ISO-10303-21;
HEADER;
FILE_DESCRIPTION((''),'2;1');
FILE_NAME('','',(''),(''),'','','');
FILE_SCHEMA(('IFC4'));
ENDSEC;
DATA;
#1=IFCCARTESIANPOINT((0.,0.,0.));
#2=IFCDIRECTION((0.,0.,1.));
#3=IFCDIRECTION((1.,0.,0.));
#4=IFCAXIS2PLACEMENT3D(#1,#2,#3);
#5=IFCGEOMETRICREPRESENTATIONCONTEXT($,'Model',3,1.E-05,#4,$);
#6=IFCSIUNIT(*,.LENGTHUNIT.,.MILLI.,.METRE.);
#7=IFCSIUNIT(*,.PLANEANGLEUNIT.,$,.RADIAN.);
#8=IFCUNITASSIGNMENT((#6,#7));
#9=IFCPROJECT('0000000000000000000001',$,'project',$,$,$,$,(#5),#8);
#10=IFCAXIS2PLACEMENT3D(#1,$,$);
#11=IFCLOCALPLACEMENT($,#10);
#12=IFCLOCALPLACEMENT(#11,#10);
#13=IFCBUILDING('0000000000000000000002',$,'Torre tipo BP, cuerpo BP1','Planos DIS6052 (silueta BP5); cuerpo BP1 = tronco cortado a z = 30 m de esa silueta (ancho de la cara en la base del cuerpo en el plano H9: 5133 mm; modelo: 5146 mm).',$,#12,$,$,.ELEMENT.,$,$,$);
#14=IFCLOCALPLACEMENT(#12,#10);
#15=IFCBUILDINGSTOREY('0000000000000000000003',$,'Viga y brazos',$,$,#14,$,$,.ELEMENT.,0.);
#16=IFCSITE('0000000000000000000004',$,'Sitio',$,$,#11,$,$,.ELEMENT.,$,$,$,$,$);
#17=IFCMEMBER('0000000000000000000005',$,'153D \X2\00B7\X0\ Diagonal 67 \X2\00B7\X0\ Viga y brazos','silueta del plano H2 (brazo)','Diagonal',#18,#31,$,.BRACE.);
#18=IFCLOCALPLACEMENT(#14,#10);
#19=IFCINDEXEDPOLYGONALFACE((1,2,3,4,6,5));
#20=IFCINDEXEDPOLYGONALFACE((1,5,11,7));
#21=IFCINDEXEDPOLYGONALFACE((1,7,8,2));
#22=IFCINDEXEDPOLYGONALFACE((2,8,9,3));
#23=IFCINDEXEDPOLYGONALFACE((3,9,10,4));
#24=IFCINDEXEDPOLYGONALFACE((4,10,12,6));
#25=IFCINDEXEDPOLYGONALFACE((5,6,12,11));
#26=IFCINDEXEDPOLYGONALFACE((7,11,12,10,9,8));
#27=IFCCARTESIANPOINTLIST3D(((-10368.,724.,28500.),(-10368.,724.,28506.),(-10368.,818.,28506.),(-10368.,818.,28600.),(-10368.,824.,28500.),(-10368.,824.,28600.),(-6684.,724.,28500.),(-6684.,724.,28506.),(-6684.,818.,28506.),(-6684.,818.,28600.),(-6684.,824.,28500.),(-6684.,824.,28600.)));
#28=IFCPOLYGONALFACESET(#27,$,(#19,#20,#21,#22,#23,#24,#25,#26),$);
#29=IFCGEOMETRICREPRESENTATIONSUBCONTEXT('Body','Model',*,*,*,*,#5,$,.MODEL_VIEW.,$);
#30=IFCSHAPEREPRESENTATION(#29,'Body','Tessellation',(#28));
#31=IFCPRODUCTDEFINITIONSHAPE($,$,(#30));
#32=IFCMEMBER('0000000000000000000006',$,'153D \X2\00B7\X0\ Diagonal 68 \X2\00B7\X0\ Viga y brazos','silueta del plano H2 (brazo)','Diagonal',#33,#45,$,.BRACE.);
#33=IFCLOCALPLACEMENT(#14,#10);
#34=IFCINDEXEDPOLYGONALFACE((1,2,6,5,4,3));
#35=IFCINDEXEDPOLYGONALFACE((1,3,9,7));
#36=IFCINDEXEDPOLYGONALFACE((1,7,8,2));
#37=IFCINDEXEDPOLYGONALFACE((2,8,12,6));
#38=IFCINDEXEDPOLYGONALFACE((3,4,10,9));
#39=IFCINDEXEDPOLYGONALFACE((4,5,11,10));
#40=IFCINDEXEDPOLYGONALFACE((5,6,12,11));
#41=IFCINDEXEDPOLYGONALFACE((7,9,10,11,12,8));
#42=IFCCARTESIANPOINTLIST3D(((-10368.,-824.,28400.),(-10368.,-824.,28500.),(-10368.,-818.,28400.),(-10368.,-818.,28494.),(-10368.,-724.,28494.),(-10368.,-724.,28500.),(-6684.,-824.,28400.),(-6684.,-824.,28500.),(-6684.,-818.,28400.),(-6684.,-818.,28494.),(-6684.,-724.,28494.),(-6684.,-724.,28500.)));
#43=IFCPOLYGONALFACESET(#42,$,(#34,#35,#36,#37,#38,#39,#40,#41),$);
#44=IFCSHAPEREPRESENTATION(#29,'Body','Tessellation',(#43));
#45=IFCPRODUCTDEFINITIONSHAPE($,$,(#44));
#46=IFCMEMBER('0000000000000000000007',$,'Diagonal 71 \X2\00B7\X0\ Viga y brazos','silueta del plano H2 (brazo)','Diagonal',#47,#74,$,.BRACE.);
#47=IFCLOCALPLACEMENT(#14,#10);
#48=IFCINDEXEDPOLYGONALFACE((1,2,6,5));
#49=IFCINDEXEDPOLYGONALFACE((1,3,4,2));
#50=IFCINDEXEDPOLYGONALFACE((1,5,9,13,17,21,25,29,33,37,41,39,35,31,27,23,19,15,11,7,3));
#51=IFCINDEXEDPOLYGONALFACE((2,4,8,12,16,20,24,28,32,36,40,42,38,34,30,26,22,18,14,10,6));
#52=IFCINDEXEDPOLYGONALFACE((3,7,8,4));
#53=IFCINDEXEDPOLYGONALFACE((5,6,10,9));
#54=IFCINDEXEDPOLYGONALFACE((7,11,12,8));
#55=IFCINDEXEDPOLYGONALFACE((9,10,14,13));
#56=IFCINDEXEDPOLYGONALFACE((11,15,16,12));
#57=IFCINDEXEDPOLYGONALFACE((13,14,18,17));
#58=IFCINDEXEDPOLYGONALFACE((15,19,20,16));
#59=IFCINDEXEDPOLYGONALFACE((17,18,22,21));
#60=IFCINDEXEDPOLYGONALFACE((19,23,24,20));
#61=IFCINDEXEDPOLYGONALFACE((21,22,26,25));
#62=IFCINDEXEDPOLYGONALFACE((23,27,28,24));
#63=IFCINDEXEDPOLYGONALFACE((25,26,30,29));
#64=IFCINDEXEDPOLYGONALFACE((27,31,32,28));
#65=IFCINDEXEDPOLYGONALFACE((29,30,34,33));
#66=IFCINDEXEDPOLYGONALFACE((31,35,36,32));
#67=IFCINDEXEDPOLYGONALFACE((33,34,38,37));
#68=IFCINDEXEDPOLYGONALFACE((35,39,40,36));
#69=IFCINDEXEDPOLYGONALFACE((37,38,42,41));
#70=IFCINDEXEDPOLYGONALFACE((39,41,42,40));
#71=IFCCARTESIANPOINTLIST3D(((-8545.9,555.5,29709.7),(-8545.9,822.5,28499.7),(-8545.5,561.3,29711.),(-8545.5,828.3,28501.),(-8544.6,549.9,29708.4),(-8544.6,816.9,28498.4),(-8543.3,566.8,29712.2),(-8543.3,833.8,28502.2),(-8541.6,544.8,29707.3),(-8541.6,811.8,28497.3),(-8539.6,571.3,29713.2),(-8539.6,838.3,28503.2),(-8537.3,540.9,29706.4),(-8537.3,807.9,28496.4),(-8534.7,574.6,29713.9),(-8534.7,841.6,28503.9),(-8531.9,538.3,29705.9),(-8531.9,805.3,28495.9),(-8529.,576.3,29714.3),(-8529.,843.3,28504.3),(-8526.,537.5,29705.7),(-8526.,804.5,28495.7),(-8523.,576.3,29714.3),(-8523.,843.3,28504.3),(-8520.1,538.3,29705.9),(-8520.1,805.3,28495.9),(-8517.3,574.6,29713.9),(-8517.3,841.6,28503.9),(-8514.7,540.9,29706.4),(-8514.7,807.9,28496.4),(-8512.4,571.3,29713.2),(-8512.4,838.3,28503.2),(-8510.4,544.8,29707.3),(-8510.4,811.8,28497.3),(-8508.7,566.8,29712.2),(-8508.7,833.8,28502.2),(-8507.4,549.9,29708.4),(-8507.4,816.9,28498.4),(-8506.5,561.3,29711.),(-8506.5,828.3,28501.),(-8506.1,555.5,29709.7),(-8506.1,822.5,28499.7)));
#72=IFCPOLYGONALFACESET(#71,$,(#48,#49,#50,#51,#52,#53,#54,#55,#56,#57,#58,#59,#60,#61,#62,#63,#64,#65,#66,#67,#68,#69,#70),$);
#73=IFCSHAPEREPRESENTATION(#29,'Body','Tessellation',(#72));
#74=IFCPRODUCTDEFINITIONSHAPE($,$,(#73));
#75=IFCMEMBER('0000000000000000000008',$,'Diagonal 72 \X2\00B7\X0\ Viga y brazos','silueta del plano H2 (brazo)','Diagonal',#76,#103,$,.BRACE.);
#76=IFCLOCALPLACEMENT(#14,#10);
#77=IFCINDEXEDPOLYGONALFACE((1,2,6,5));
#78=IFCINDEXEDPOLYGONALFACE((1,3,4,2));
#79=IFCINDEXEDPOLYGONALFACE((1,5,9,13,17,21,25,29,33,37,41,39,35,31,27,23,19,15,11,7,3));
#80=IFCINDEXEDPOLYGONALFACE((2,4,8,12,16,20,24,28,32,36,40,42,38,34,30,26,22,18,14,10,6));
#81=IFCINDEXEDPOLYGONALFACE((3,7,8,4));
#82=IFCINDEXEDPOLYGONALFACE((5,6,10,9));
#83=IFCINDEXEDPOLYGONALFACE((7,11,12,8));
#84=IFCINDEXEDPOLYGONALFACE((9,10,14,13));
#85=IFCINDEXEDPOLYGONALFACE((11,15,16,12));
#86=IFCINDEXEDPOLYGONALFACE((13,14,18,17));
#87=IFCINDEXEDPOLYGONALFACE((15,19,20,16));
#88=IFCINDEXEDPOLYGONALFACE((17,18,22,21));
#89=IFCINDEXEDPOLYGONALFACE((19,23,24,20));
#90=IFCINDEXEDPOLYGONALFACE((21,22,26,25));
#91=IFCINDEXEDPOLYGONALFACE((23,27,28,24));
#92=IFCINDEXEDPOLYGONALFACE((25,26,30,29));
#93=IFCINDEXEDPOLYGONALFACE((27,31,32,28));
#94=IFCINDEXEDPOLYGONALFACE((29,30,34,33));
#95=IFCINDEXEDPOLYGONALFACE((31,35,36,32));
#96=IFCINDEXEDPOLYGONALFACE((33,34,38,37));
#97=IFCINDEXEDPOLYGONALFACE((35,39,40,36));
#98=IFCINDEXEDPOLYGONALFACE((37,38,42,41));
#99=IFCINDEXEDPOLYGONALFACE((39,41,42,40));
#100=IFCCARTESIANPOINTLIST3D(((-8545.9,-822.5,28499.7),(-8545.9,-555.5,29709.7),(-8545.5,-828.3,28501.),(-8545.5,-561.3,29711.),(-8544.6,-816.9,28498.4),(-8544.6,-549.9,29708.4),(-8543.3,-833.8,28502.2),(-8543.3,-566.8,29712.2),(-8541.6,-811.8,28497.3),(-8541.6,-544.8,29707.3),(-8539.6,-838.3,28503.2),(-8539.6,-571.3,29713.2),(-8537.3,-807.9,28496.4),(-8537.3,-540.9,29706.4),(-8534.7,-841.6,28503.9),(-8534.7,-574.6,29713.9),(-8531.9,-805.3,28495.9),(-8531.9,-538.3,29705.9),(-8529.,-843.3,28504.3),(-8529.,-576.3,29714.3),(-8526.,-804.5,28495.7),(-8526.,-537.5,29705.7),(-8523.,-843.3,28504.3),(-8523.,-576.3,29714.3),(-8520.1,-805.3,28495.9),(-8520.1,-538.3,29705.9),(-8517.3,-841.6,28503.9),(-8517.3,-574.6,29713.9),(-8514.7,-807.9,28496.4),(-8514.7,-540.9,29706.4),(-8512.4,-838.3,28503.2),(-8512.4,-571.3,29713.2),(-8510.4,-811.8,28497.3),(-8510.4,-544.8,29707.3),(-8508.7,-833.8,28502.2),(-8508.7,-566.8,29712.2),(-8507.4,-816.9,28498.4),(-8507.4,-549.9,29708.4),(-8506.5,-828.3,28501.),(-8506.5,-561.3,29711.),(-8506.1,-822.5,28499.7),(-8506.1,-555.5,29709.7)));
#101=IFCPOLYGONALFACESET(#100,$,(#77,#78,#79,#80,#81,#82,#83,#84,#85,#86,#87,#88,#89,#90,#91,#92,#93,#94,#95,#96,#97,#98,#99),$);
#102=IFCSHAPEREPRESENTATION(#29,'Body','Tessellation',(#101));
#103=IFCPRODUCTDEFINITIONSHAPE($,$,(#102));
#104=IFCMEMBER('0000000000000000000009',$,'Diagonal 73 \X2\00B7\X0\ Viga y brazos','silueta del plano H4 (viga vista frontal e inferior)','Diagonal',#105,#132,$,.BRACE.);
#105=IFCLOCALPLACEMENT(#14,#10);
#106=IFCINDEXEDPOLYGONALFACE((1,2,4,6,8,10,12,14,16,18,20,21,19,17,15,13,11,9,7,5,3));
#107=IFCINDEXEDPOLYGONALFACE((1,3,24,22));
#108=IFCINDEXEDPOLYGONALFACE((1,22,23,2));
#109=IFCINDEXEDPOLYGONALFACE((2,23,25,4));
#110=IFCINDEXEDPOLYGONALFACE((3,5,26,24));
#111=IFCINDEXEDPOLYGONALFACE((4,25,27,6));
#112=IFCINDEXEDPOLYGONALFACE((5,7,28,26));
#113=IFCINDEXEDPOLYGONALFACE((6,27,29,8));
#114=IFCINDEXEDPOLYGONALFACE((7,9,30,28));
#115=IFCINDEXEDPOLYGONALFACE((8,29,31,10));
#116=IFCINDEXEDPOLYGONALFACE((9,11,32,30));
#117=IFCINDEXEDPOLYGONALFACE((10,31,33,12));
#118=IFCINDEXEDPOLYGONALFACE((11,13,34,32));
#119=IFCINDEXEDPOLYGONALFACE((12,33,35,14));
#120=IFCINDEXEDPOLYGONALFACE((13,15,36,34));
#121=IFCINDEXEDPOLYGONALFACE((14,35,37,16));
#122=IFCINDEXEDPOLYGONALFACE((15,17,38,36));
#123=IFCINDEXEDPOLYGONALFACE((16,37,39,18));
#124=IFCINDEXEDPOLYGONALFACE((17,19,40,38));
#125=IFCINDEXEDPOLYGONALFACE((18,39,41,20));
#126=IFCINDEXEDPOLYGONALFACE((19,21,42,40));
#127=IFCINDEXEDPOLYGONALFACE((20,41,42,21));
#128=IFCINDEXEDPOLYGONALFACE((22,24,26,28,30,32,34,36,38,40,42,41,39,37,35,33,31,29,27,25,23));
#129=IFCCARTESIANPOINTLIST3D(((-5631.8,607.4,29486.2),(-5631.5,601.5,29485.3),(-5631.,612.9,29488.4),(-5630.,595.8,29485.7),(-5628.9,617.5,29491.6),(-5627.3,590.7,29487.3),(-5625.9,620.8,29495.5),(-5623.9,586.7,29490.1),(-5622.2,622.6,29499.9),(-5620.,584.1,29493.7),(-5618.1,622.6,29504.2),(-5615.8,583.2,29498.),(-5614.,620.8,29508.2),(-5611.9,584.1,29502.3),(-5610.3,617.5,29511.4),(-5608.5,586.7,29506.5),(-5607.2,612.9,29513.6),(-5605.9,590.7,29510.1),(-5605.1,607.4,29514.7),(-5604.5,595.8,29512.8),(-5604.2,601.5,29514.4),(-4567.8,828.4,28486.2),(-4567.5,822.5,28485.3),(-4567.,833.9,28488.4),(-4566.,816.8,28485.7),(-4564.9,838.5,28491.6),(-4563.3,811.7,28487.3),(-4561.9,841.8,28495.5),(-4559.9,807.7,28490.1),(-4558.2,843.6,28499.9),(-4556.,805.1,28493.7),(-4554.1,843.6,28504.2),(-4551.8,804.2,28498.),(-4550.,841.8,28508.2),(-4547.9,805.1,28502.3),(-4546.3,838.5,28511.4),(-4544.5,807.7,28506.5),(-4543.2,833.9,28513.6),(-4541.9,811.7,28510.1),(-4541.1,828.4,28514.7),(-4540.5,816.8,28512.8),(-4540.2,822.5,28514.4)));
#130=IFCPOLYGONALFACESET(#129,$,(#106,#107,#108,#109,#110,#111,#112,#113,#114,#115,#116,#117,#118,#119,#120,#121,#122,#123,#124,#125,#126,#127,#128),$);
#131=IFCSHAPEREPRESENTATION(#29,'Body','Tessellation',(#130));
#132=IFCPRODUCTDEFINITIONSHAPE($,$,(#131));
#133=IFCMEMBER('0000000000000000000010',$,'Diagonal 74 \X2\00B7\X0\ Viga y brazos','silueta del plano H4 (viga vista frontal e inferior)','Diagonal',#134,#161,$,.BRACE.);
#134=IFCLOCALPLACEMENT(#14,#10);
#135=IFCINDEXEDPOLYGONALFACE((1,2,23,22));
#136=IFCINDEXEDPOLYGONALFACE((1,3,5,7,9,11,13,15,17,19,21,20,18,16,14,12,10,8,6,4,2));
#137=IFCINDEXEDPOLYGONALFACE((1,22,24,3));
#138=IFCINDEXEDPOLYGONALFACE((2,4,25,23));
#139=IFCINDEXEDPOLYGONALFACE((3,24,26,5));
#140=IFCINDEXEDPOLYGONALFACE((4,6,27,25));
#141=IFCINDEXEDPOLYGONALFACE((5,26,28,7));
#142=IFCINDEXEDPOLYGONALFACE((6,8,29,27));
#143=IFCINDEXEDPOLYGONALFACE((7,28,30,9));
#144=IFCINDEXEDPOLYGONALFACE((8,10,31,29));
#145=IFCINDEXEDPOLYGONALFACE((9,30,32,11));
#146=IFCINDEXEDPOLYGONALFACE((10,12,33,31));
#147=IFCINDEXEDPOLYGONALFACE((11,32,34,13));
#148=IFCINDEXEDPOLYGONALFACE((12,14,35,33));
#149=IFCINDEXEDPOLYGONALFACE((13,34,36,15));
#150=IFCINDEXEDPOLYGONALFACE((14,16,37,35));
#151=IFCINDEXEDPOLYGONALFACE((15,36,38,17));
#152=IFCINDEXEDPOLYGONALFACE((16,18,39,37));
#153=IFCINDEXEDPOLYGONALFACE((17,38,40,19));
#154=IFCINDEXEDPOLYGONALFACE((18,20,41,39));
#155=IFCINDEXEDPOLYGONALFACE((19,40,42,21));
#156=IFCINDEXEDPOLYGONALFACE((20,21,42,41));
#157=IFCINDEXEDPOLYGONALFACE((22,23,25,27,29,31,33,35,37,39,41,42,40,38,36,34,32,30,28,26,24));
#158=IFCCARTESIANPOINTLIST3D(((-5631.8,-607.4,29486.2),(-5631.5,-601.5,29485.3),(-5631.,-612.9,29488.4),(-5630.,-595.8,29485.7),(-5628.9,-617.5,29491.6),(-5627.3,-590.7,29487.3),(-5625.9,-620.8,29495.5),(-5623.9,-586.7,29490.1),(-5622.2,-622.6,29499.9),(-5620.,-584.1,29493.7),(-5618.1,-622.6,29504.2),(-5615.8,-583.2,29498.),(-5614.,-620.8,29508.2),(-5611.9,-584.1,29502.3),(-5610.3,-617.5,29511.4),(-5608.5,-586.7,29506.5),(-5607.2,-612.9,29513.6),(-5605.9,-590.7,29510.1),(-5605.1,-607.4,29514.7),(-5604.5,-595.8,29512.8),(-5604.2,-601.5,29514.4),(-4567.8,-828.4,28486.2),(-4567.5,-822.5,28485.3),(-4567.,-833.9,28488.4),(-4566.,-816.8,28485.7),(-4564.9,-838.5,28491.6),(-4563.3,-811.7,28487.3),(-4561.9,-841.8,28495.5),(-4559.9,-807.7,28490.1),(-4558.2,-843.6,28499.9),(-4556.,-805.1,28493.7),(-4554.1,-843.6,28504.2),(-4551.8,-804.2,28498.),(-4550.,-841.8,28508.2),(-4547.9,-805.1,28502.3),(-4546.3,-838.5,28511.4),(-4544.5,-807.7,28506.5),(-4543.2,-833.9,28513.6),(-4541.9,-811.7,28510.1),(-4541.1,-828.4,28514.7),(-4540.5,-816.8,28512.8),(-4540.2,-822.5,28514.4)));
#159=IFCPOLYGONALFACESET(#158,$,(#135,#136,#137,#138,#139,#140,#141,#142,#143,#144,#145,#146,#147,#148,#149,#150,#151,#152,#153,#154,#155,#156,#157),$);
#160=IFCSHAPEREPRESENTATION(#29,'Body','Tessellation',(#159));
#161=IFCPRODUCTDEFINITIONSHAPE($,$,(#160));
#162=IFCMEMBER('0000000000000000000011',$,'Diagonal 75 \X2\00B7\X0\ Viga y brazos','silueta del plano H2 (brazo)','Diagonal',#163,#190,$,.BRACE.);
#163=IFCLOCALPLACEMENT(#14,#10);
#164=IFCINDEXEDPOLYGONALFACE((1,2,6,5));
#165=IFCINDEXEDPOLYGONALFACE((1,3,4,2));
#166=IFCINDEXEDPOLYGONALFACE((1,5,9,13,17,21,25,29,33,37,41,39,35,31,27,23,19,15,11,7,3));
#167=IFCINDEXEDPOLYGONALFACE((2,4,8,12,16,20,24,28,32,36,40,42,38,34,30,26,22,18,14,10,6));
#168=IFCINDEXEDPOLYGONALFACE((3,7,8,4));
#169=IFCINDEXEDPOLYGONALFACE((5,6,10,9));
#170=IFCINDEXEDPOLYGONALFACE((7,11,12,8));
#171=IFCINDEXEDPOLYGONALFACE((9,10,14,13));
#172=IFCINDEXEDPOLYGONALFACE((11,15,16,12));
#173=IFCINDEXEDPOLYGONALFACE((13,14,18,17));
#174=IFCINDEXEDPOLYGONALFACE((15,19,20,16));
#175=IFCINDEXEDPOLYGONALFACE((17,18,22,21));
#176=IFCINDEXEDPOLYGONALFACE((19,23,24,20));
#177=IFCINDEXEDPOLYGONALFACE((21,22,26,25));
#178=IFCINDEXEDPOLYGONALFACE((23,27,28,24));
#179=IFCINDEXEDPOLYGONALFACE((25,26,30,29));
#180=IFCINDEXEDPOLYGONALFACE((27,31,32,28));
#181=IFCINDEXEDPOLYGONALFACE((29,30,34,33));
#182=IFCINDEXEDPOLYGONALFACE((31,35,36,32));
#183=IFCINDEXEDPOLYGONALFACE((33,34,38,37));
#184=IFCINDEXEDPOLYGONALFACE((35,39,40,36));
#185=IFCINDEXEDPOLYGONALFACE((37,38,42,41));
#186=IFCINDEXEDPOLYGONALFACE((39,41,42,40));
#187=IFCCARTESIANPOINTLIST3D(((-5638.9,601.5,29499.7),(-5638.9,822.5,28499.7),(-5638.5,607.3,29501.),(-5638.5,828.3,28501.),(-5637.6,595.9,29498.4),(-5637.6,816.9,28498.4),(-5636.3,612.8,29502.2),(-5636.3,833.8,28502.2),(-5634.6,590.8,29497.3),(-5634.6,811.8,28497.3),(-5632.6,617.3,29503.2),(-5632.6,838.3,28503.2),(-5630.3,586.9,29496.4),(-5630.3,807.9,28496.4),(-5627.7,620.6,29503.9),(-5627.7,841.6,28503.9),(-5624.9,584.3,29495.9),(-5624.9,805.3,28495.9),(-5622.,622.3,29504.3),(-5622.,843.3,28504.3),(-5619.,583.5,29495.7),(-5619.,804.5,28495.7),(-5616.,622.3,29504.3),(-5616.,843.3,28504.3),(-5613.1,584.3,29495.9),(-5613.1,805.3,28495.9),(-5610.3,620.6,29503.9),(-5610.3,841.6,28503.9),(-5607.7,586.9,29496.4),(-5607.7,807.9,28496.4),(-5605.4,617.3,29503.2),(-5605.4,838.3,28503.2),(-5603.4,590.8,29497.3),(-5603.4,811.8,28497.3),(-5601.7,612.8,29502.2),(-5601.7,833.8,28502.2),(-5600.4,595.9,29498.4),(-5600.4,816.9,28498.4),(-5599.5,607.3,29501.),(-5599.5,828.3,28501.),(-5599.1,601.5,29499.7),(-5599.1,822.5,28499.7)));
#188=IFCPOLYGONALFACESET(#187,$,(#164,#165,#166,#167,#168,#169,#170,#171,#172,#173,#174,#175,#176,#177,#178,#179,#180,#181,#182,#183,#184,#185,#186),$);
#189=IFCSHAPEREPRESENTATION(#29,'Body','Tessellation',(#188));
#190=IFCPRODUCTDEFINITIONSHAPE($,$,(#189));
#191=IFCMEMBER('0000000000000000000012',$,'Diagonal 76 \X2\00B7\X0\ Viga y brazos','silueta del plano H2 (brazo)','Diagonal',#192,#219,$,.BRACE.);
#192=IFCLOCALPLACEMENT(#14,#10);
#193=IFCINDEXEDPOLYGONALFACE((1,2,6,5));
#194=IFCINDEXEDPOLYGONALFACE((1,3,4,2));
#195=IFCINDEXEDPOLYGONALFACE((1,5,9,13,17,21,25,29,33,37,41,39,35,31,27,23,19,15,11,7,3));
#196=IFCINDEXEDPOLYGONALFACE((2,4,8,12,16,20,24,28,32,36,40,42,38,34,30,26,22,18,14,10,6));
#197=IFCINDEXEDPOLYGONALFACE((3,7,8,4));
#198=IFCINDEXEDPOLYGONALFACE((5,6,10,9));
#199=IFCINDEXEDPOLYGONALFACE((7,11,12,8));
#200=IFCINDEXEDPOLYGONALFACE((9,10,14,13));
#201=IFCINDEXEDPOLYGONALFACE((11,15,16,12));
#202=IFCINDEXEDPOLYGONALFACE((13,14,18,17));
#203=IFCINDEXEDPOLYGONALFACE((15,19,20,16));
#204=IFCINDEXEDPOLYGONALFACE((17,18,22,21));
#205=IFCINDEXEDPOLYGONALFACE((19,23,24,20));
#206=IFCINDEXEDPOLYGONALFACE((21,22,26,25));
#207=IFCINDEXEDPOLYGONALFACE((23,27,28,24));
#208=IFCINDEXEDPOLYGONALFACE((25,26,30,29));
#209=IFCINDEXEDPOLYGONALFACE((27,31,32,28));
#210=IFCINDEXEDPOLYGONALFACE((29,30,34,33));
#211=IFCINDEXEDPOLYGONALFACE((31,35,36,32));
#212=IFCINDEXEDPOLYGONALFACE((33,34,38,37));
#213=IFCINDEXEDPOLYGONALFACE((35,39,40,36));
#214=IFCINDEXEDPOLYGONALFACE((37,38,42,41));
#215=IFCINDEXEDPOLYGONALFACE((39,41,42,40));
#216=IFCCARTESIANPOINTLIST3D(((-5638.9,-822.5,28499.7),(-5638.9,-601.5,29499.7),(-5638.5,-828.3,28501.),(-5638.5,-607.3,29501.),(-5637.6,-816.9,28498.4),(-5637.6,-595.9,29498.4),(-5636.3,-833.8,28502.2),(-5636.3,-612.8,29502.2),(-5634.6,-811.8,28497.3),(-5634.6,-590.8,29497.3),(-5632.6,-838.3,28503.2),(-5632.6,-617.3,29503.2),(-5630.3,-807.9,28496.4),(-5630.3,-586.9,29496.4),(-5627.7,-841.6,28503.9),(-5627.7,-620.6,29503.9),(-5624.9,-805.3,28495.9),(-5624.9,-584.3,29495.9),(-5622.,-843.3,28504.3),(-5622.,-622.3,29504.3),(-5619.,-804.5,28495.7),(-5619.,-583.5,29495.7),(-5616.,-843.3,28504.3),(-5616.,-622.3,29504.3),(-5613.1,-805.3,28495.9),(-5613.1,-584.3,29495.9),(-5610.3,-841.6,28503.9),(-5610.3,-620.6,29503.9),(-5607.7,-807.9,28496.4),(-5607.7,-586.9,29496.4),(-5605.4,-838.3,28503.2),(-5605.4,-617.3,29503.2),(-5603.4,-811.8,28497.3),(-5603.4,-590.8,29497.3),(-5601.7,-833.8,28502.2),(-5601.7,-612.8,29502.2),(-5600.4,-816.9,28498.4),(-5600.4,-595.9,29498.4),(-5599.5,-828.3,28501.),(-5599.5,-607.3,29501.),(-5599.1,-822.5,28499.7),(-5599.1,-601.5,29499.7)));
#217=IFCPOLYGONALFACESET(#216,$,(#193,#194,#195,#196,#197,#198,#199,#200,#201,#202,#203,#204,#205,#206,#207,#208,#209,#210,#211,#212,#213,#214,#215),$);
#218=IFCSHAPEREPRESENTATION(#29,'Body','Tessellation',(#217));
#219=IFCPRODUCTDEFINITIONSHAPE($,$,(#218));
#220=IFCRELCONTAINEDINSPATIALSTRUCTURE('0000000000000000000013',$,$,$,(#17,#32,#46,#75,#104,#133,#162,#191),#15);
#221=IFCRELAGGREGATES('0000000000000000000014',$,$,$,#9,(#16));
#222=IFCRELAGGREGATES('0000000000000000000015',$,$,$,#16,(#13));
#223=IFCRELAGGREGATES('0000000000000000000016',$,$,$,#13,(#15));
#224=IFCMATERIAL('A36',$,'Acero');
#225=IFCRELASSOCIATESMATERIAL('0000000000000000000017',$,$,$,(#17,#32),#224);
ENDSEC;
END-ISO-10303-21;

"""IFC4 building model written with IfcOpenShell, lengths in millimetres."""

from ifc_helpers import new_model, si_unit, frame, frame_2d, origin, origin_with_axes, place, context, subcontext, project, spatial, circle, l_section, extrude, material, element, save


model = new_model("IFC4")

# Units and contexts
model_context = context("Model", 3, precision=1e-05, world=origin_with_axes())
body_context = subcontext(model_context, "Body", "Model", "MODEL_VIEW")
ifc_project = project(units=[si_unit("LENGTHUNIT", "METRE", prefix="MILLI"), si_unit("PLANEANGLEUNIT", "RADIAN")], contexts=[model_context])

# Site, building, storey
site_placement = place(None, origin())
site = spatial("IfcSite", under=ifc_project, at=site_placement, Name="Sitio", CompositionType="ELEMENT")
building_placement = place(site_placement, origin())
building = spatial("IfcBuilding", under=site, at=building_placement, Name="Torre tipo BP, cuerpo BP1", Description="Planos DIS6052 (silueta BP5); cuerpo BP1 = tronco cortado a z = 30 m de esa silueta (ancho de la cara en la base del cuerpo en el plano H9: 5133 mm; modelo: 5146 mm).", CompositionType="ELEMENT")
storey_placement = place(building_placement, origin())
storey = spatial("IfcBuildingStorey", under=building, at=storey_placement, Name="Viga y brazos", CompositionType="ELEMENT", Elevation=0.0)

# Members
ifc_material_1 = material(Name="A36", Category="Acero")
for number, where, z_axis, x_axis, name in (
    (1, (-6684.0, 824.0, 28500.0), (-1.0, 0.0, 0.0), (0.0, -1.0, 0.0), "153D · Diagonal 67 · Viga y brazos"),
    (2, (-6684.0, -824.0, 28500.0), (-1.0, 0.0, 0.0), (0.0, 1.0, 0.0), "153D · Diagonal 68 · Viga y brazos"),
):
    element("IfcMember", number, at=place(storey_placement, frame(where, z_axis=z_axis, x_axis=x_axis)), inside=storey, material=ifc_material_1, Name=name, Description="silueta del plano H2 (brazo)", ObjectType="Diagonal", PredefinedType="BRACE", context=body_context, shape_type="SweptSolid", body=[
        extrude(l_section(Depth=100.0, Width=100.0, Thickness=6.0, at=frame_2d((50.0, 50.0))), None, (0.0, 0.0, 1.0), 3684.0),
    ])
for number, where, z_axis, x_axis, name in (
    (3, (-8526.0, 557.0, 29710.0), (0.0, 0.215478, -0.976509), (0.0, -0.976509, -0.215478), "Diagonal 71 · Viga y brazos"),
    (4, (-8526.0, -557.0, 29710.0), (0.0, -0.215478, -0.976509), (0.0, 0.976509, -0.215478), "Diagonal 72 · Viga y brazos"),
):
    element("IfcMember", number, at=place(storey_placement, frame(where, z_axis=z_axis, x_axis=x_axis)), inside=storey, Name=name, Description="silueta del plano H2 (brazo)", ObjectType="Diagonal", PredefinedType="BRACE", context=body_context, shape_type="SweptSolid", body=[
        extrude(circle(Radius=20.0), None, (0.0, 0.0, 1.0), 1239.1),
    ])
for number, where, z_axis, x_axis, name in (
    (5, (-4554.0, 824.0, 28500.0), (-0.720477, -0.149648, 0.67714), (0.109046, -0.988739, -0.102487), "Diagonal 73 · Viga y brazos"),
    (6, (-4554.0, -824.0, 28500.0), (-0.720477, 0.149648, 0.67714), (0.109046, 0.988739, -0.102487), "Diagonal 74 · Viga y brazos"),
):
    element("IfcMember", number, at=place(storey_placement, frame(where, z_axis=z_axis, x_axis=x_axis)), inside=storey, Name=name, Description="silueta del plano H4 (viga vista frontal e inferior)", ObjectType="Diagonal", PredefinedType="BRACE", context=body_context, shape_type="SweptSolid", body=[
        extrude(circle(Radius=20.0), None, (0.0, 0.0, 1.0), 1476.8),
    ])
for number, where, z_axis, x_axis, name in (
    (7, (-5619.0, 824.0, 28500.0), (0.0, -0.215793, 0.976439), (0.0, -0.976439, -0.215793), "Diagonal 75 · Viga y brazos"),
    (8, (-5619.0, -824.0, 28500.0), (0.0, 0.215793, 0.976439), (0.0, 0.976439, -0.215793), "Diagonal 76 · Viga y brazos"),
):
    element("IfcMember", number, at=place(storey_placement, frame(where, z_axis=z_axis, x_axis=x_axis)), inside=storey, Name=name, Description="silueta del plano H2 (brazo)", ObjectType="Diagonal", PredefinedType="BRACE", context=body_context, shape_type="SweptSolid", body=[
        extrude(circle(Radius=20.0), None, (0.0, 0.0, 1.0), 1024.1),
    ])

save(model, "model.ifc")
